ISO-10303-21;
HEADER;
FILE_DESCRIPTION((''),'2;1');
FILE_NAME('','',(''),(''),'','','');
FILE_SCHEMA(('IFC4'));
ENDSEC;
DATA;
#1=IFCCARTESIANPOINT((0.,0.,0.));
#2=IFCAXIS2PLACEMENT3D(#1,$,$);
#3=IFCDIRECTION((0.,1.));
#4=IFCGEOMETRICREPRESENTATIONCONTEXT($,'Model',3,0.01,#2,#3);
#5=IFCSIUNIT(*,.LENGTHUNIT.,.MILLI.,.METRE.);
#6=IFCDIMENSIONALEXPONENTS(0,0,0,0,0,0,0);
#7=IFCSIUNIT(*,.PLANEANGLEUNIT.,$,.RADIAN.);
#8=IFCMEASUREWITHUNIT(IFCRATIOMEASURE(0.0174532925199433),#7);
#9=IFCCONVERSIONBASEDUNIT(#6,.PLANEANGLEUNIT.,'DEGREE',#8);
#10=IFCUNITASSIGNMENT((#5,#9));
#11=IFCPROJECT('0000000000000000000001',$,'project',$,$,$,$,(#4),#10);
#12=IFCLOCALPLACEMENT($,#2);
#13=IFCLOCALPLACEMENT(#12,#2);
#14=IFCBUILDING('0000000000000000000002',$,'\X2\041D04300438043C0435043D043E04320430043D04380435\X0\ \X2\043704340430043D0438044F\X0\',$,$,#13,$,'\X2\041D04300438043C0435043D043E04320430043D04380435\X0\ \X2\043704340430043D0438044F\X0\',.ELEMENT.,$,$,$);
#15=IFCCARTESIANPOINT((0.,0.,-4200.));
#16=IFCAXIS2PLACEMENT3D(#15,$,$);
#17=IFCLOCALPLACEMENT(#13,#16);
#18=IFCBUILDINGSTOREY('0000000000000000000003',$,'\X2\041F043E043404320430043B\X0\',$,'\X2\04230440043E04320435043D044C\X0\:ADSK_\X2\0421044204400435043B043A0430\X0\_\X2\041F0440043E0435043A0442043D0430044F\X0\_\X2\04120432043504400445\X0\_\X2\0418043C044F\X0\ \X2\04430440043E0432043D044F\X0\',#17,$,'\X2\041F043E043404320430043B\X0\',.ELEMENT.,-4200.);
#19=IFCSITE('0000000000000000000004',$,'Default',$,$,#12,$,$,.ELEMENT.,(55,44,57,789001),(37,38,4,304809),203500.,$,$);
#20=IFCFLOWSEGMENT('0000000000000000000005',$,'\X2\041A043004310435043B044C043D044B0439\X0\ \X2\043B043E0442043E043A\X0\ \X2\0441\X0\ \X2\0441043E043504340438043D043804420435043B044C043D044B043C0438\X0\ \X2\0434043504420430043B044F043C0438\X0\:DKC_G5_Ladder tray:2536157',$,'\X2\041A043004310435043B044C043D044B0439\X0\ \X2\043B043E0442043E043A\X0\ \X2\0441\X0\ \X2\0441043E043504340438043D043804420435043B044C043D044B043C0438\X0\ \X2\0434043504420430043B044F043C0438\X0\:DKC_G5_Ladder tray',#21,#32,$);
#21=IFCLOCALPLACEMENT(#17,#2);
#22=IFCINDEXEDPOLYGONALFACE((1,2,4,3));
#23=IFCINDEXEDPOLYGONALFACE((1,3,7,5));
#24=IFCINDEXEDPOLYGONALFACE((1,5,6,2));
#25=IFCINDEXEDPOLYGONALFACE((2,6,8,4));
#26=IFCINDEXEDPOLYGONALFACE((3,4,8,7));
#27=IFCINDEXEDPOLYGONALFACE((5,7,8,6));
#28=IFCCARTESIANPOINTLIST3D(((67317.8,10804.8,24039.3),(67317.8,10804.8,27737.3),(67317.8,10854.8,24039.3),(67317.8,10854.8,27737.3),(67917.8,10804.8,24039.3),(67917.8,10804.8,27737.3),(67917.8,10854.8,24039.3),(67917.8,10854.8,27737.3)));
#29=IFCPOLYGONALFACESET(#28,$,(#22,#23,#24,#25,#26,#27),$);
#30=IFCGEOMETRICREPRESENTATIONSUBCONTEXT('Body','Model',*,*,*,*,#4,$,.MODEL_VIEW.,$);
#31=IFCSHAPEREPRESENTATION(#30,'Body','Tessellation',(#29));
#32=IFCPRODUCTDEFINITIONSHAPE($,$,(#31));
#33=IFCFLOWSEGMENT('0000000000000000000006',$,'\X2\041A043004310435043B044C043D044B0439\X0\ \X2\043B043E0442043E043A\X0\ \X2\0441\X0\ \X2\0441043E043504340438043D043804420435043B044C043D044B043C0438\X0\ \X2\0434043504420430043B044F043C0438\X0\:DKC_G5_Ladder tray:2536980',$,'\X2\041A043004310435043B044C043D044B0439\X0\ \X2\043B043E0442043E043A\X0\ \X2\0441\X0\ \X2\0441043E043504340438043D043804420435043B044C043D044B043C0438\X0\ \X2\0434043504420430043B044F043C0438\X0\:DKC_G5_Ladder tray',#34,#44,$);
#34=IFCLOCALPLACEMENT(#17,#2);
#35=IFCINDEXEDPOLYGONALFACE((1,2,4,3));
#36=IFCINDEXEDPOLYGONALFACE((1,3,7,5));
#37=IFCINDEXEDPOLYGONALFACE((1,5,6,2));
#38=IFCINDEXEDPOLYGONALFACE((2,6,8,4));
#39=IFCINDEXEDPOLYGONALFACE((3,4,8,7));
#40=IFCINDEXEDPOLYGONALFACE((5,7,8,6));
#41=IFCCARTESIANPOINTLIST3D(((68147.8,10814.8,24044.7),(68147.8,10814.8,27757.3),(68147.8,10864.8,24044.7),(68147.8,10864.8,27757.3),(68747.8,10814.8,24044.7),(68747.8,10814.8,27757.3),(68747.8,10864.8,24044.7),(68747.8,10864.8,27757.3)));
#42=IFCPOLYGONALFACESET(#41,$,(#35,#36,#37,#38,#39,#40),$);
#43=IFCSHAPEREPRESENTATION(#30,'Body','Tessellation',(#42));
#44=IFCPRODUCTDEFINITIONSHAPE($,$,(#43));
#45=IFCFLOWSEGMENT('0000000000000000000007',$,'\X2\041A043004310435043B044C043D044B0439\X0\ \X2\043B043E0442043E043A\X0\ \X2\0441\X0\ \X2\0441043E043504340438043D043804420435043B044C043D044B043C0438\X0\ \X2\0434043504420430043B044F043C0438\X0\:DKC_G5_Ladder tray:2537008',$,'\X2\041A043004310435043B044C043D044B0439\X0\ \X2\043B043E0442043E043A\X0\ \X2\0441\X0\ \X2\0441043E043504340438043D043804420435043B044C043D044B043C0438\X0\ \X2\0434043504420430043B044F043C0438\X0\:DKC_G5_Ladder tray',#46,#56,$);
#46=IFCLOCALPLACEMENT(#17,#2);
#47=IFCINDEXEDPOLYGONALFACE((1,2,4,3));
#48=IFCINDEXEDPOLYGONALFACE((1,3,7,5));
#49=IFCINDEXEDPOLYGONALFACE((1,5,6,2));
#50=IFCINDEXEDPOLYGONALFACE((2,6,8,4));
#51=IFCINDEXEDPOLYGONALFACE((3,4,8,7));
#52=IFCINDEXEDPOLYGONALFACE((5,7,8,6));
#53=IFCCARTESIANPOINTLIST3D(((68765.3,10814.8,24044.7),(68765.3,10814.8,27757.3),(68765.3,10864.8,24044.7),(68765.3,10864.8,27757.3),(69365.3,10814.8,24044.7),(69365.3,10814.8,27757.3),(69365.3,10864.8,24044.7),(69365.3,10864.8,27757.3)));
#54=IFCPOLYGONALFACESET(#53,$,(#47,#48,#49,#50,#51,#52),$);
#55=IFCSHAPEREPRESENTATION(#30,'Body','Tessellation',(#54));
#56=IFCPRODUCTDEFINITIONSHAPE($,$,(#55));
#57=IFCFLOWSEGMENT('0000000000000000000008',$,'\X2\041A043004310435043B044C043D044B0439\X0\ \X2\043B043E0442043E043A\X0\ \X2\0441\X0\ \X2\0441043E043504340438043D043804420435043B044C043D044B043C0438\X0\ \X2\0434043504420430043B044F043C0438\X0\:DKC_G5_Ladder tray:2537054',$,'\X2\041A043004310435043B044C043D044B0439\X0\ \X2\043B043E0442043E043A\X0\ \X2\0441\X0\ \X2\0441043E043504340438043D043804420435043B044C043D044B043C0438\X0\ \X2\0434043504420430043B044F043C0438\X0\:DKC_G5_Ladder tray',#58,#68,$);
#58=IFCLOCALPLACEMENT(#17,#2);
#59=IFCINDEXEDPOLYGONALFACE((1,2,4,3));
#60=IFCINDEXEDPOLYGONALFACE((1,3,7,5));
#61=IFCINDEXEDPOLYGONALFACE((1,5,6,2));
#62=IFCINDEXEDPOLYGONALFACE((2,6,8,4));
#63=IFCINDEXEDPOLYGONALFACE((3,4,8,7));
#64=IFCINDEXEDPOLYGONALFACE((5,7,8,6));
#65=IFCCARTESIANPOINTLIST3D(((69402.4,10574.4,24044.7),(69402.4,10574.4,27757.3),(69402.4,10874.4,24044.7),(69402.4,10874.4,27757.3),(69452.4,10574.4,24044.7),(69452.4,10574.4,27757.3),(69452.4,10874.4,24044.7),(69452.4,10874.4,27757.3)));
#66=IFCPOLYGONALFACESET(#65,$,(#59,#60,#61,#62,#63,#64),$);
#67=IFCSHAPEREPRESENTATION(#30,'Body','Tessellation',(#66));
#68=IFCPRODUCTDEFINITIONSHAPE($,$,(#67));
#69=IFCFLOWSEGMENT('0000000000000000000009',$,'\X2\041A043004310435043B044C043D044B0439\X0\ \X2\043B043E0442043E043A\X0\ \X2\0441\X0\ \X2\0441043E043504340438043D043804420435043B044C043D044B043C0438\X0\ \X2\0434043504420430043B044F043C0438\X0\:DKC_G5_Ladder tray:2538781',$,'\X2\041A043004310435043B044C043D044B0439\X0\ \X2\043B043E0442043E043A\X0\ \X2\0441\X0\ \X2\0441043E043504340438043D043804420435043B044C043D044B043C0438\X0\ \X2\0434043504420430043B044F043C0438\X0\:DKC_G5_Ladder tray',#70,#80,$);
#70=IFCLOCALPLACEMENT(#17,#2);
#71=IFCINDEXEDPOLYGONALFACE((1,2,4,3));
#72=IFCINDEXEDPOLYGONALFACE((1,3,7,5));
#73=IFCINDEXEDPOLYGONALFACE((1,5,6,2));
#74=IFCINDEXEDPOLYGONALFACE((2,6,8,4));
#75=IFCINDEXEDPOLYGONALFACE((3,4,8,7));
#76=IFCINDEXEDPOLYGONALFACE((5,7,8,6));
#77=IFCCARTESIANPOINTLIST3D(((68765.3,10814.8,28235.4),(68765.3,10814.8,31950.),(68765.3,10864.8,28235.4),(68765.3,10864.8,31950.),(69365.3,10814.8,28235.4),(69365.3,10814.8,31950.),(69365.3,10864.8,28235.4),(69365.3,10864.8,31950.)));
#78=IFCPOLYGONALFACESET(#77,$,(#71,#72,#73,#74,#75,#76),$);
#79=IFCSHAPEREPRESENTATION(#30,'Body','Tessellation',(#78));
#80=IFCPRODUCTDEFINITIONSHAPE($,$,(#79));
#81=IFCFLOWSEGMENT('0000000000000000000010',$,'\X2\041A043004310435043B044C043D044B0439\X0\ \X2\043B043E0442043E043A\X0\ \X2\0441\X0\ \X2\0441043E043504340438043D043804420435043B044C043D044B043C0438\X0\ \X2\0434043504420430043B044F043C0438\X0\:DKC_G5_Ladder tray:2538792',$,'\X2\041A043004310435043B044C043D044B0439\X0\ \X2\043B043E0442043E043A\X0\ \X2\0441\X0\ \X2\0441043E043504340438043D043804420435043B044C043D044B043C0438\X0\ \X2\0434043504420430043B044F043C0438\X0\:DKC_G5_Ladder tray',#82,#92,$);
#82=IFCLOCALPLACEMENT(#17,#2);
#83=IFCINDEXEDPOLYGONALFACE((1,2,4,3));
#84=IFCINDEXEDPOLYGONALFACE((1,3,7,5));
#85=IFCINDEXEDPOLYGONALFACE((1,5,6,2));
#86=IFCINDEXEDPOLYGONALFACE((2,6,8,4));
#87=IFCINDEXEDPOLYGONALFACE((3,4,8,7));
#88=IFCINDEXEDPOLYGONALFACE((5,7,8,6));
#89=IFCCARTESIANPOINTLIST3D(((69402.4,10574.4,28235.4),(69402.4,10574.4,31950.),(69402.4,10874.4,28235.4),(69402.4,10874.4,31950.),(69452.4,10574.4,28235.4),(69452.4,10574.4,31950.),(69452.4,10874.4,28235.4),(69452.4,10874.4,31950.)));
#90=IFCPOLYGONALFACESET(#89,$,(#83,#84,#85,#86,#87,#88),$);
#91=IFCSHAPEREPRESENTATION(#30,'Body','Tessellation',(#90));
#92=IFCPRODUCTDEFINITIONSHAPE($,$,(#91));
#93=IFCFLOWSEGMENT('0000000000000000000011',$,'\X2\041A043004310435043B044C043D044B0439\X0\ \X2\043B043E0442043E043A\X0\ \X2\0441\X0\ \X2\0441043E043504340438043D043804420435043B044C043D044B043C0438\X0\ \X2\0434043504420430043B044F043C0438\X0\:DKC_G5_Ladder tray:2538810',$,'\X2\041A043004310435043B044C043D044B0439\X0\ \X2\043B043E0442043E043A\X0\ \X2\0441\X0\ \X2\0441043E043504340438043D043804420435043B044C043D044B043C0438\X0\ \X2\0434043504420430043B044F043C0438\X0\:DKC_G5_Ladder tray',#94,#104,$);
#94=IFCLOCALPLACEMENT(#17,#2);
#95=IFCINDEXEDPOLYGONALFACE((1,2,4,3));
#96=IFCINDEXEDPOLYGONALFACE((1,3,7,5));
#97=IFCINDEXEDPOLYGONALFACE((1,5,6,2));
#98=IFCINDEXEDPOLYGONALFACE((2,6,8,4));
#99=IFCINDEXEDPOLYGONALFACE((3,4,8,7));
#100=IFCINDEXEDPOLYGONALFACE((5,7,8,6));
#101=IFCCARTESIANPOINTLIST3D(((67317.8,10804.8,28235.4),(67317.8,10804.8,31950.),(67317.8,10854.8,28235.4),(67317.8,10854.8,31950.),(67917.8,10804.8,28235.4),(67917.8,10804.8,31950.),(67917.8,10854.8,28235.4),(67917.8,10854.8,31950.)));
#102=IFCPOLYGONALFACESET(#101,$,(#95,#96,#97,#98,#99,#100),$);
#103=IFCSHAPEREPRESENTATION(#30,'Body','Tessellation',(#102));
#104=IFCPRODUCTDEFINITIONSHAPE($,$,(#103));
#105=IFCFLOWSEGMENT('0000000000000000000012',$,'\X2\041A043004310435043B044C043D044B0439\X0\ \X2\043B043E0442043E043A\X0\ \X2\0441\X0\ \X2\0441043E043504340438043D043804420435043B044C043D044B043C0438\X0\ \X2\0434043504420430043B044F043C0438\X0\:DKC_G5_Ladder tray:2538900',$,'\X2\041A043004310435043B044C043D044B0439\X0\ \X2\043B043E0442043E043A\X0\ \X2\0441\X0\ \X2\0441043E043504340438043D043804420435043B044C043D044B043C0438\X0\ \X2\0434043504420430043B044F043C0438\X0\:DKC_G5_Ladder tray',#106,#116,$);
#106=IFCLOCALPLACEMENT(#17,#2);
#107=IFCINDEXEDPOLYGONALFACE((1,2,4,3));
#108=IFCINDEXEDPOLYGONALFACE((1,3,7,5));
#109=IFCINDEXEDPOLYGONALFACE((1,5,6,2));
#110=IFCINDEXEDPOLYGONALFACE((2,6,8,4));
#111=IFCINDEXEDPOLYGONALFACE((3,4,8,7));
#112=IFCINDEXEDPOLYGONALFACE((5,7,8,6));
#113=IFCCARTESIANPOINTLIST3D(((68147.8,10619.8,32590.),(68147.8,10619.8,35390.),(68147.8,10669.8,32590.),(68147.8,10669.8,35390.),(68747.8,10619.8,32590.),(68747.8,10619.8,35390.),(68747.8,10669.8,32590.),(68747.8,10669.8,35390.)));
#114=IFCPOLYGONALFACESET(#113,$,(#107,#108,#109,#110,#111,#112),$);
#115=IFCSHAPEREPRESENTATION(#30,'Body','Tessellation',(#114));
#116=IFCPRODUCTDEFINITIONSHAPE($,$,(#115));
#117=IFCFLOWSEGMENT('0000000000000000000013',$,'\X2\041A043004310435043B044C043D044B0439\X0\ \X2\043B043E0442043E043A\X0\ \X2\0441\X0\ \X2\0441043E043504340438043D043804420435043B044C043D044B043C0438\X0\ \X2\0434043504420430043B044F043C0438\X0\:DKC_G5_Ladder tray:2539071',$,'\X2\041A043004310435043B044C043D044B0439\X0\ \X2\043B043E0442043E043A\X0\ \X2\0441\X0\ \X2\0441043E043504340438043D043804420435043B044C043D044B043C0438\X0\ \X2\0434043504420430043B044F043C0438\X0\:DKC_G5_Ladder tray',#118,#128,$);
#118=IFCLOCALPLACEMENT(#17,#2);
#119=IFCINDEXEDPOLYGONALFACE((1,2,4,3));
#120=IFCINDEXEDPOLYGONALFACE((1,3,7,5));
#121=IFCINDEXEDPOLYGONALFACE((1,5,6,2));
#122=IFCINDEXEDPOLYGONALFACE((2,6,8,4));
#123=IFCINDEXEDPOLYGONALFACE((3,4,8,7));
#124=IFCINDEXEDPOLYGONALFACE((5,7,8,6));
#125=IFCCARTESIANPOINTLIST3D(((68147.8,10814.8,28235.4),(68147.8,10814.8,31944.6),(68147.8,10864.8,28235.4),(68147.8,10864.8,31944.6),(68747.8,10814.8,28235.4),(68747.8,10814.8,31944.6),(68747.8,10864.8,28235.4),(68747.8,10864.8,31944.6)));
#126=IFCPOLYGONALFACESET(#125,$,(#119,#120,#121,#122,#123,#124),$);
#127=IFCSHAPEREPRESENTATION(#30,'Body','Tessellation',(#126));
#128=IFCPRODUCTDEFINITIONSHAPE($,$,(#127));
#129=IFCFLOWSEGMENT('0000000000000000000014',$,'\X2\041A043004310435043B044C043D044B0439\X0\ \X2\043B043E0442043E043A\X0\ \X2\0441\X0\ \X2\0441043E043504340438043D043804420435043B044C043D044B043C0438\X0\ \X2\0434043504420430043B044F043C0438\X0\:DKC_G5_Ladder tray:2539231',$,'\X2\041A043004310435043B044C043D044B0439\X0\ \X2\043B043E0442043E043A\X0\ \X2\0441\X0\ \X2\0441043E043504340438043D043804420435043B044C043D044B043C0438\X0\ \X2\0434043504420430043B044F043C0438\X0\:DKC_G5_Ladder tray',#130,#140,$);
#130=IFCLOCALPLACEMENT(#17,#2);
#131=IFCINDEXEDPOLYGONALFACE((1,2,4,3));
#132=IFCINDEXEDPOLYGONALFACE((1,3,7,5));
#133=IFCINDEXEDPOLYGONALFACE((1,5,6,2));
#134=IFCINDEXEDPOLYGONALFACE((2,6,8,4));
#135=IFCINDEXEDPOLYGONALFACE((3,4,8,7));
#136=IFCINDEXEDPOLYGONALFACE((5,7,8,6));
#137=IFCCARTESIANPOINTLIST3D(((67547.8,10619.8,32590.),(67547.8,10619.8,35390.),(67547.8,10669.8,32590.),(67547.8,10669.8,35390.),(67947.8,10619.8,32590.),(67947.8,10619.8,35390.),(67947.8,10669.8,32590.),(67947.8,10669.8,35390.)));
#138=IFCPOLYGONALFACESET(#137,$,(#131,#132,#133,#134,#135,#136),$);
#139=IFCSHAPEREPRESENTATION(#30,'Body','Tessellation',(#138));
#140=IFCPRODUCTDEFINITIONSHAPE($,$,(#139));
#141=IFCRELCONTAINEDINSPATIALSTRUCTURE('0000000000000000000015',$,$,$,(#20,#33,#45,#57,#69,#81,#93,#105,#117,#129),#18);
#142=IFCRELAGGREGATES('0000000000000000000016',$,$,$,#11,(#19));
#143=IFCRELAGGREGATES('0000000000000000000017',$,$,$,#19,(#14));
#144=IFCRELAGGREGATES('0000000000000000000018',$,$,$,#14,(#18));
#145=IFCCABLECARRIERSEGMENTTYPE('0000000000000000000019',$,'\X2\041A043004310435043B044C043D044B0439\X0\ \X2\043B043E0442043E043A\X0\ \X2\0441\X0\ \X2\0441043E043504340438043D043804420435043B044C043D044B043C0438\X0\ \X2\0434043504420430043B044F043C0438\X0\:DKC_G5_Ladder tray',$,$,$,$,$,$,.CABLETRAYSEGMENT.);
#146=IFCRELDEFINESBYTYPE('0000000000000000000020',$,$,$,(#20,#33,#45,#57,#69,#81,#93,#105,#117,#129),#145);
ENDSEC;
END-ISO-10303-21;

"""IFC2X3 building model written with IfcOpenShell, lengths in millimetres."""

from ifc_helpers import new_model, entity, si_unit, converted_unit, direction, frame, origin, origin_2d_with_axis, place, context, subcontext, project, spatial, rectangle, extrude, type_object, element, save


model = new_model("IFC2X3")

# Units and contexts
model_context = context("Model", 3, precision=0.01, world=origin(), true_north=direction((0.0, 1.0)))
body_context = subcontext(model_context, "Body", "Model", "MODEL_VIEW")
ifc_project = project(units=[si_unit("LENGTHUNIT", "METRE", prefix="MILLI"), converted_unit("PLANEANGLEUNIT", "DEGREE", entity("IfcRatioMeasure", 0.0174532925199433), si_unit("PLANEANGLEUNIT", "RADIAN"), dimensions=[0, 0, 0, 0, 0, 0, 0])], contexts=[model_context])

# Site, building, storey
site_placement = place(None, origin())
site = spatial("IfcSite", under=ifc_project, at=site_placement, Name="Default", CompositionType="ELEMENT", RefLatitude=(55, 44, 57, 789001), RefLongitude=(37, 38, 4, 304809), RefElevation=203500.0)
building_placement = place(site_placement, origin())
building = spatial("IfcBuilding", under=site, at=building_placement, Name="Наименование здания", LongName="Наименование здания", CompositionType="ELEMENT")
storey_placement = place(building_placement, frame((0.0, 0.0, -4200.0)))
storey = spatial("IfcBuildingStorey", under=building, at=storey_placement, Name="Подвал", ObjectType="Уровень:ADSK_Стрелка_Проектная_Вверх_Имя уровня", LongName="Подвал", CompositionType="ELEMENT", Elevation=-4200.0)

# Flow segments
cable_carrier_segment_type = type_object("IfcCableCarrierSegmentType", Name="Кабельный лоток с соединительными деталями:DKC_G5_Ladder tray", PredefinedType="CABLETRAYSEGMENT")
flow_segment_1_placement = place(storey_placement, frame((67317.8, 10804.8, 24039.3)))
element("IfcFlowSegment", 1, at=flow_segment_1_placement, inside=storey, type_object=cable_carrier_segment_type, Name="Кабельный лоток с соединительными деталями:DKC_G5_Ladder tray:2536157", ObjectType="Кабельный лоток с соединительными деталями:DKC_G5_Ladder tray", context=body_context, shape_type="SweptSolid", body=[
    extrude(rectangle(XDim=50.0, YDim=600.0, at=origin_2d_with_axis()), frame((300.0, 25.0, 0.0), z_axis=(0.0, 0.0, 1.0), x_axis=(0.0, 1.0, 0.0)), (0.0, 0.0, 1.0), 3698.0),
])
flow_segment_2_placement = place(storey_placement, frame((68147.8, 10814.8, 24044.7)))
element("IfcFlowSegment", 2, at=flow_segment_2_placement, inside=storey, type_object=cable_carrier_segment_type, Name="Кабельный лоток с соединительными деталями:DKC_G5_Ladder tray:2536980", ObjectType="Кабельный лоток с соединительными деталями:DKC_G5_Ladder tray", context=body_context, shape_type="SweptSolid", body=[
    extrude(rectangle(XDim=600.0, YDim=50.0, at=origin_2d_with_axis()), frame((300.0, 25.0, 0.0)), (0.0, 0.0, 1.0), 3712.6),
])
flow_segment_3_placement = place(storey_placement, frame((68765.3, 10814.8, 24044.7)))
element("IfcFlowSegment", 3, at=flow_segment_3_placement, inside=storey, type_object=cable_carrier_segment_type, Name="Кабельный лоток с соединительными деталями:DKC_G5_Ladder tray:2537008", ObjectType="Кабельный лоток с соединительными деталями:DKC_G5_Ladder tray", context=body_context, shape_type="SweptSolid", body=[
    extrude(rectangle(XDim=600.0, YDim=50.0, at=origin_2d_with_axis()), frame((300.0, 25.0, 0.0)), (0.0, 0.0, 1.0), 3712.6),
])
flow_segment_4_placement = place(storey_placement, frame((69402.4, 10574.4, 24044.7)))
element("IfcFlowSegment", 4, at=flow_segment_4_placement, inside=storey, type_object=cable_carrier_segment_type, Name="Кабельный лоток с соединительными деталями:DKC_G5_Ladder tray:2537054", ObjectType="Кабельный лоток с соединительными деталями:DKC_G5_Ladder tray", context=body_context, shape_type="SweptSolid", body=[
    extrude(rectangle(XDim=300.0, YDim=50.0, at=origin_2d_with_axis()), frame((25.0, 150.0, 0.0), z_axis=(0.0, 0.0, 1.0), x_axis=(0.0, -1.0, 0.0)), (0.0, 0.0, 1.0), 3712.6),
])
flow_segment_5_placement = place(storey_placement, frame((68765.3, 10814.8, 28235.4)))
element("IfcFlowSegment", 5, at=flow_segment_5_placement, inside=storey, type_object=cable_carrier_segment_type, Name="Кабельный лоток с соединительными деталями:DKC_G5_Ladder tray:2538781", ObjectType="Кабельный лоток с соединительными деталями:DKC_G5_Ladder tray", context=body_context, shape_type="SweptSolid", body=[
    extrude(rectangle(XDim=600.0, YDim=50.0, at=origin_2d_with_axis()), frame((300.0, 25.0, 0.0)), (0.0, 0.0, 1.0), 3714.6),
])
flow_segment_6_placement = place(storey_placement, frame((69402.4, 10574.4, 28235.4)))
element("IfcFlowSegment", 6, at=flow_segment_6_placement, inside=storey, type_object=cable_carrier_segment_type, Name="Кабельный лоток с соединительными деталями:DKC_G5_Ladder tray:2538792", ObjectType="Кабельный лоток с соединительными деталями:DKC_G5_Ladder tray", context=body_context, shape_type="SweptSolid", body=[
    extrude(rectangle(XDim=300.0, YDim=50.0, at=origin_2d_with_axis()), frame((25.0, 150.0, 0.0), z_axis=(0.0, 0.0, 1.0), x_axis=(0.0, -1.0, 0.0)), (0.0, 0.0, 1.0), 3714.6),
])
flow_segment_7_placement = place(storey_placement, frame((67317.8, 10804.8, 28235.4)))
element("IfcFlowSegment", 7, at=flow_segment_7_placement, inside=storey, type_object=cable_carrier_segment_type, Name="Кабельный лоток с соединительными деталями:DKC_G5_Ladder tray:2538810", ObjectType="Кабельный лоток с соединительными деталями:DKC_G5_Ladder tray", context=body_context, shape_type="SweptSolid", body=[
    extrude(rectangle(XDim=600.0, YDim=50.0, at=origin_2d_with_axis()), frame((300.0, 25.0, 0.0)), (0.0, 0.0, 1.0), 3714.6),
])
flow_segment_8_placement = place(storey_placement, frame((68147.8, 10619.8, 32590.0)))
element("IfcFlowSegment", 8, at=flow_segment_8_placement, inside=storey, type_object=cable_carrier_segment_type, Name="Кабельный лоток с соединительными деталями:DKC_G5_Ladder tray:2538900", ObjectType="Кабельный лоток с соединительными деталями:DKC_G5_Ladder tray", context=body_context, shape_type="SweptSolid", body=[
    extrude(rectangle(XDim=600.0, YDim=50.0, at=origin_2d_with_axis()), frame((300.0, 25.0, 0.0)), (0.0, 0.0, 1.0), 2800.0),
])
flow_segment_9_placement = place(storey_placement, frame((68147.8, 10814.8, 28235.4)))
element("IfcFlowSegment", 9, at=flow_segment_9_placement, inside=storey, type_object=cable_carrier_segment_type, Name="Кабельный лоток с соединительными деталями:DKC_G5_Ladder tray:2539071", ObjectType="Кабельный лоток с соединительными деталями:DKC_G5_Ladder tray", context=body_context, shape_type="SweptSolid", body=[
    extrude(rectangle(XDim=600.0, YDim=50.0, at=origin_2d_with_axis()), frame((300.0, 25.0, 0.0)), (0.0, 0.0, 1.0), 3709.2),
])
flow_segment_10_placement = place(storey_placement, frame((67547.8, 10619.8, 32590.0)))
element("IfcFlowSegment", 10, at=flow_segment_10_placement, inside=storey, type_object=cable_carrier_segment_type, Name="Кабельный лоток с соединительными деталями:DKC_G5_Ladder tray:2539231", ObjectType="Кабельный лоток с соединительными деталями:DKC_G5_Ladder tray", context=body_context, shape_type="SweptSolid", body=[
    extrude(rectangle(XDim=400.0, YDim=50.0, at=origin_2d_with_axis()), frame((200.0, 25.0, 0.0), z_axis=(0.0, 0.0, 1.0), x_axis=(-1.0, 0.0, 0.0)), (0.0, 0.0, 1.0), 2800.0),
])

save(model, "model.ifc")
